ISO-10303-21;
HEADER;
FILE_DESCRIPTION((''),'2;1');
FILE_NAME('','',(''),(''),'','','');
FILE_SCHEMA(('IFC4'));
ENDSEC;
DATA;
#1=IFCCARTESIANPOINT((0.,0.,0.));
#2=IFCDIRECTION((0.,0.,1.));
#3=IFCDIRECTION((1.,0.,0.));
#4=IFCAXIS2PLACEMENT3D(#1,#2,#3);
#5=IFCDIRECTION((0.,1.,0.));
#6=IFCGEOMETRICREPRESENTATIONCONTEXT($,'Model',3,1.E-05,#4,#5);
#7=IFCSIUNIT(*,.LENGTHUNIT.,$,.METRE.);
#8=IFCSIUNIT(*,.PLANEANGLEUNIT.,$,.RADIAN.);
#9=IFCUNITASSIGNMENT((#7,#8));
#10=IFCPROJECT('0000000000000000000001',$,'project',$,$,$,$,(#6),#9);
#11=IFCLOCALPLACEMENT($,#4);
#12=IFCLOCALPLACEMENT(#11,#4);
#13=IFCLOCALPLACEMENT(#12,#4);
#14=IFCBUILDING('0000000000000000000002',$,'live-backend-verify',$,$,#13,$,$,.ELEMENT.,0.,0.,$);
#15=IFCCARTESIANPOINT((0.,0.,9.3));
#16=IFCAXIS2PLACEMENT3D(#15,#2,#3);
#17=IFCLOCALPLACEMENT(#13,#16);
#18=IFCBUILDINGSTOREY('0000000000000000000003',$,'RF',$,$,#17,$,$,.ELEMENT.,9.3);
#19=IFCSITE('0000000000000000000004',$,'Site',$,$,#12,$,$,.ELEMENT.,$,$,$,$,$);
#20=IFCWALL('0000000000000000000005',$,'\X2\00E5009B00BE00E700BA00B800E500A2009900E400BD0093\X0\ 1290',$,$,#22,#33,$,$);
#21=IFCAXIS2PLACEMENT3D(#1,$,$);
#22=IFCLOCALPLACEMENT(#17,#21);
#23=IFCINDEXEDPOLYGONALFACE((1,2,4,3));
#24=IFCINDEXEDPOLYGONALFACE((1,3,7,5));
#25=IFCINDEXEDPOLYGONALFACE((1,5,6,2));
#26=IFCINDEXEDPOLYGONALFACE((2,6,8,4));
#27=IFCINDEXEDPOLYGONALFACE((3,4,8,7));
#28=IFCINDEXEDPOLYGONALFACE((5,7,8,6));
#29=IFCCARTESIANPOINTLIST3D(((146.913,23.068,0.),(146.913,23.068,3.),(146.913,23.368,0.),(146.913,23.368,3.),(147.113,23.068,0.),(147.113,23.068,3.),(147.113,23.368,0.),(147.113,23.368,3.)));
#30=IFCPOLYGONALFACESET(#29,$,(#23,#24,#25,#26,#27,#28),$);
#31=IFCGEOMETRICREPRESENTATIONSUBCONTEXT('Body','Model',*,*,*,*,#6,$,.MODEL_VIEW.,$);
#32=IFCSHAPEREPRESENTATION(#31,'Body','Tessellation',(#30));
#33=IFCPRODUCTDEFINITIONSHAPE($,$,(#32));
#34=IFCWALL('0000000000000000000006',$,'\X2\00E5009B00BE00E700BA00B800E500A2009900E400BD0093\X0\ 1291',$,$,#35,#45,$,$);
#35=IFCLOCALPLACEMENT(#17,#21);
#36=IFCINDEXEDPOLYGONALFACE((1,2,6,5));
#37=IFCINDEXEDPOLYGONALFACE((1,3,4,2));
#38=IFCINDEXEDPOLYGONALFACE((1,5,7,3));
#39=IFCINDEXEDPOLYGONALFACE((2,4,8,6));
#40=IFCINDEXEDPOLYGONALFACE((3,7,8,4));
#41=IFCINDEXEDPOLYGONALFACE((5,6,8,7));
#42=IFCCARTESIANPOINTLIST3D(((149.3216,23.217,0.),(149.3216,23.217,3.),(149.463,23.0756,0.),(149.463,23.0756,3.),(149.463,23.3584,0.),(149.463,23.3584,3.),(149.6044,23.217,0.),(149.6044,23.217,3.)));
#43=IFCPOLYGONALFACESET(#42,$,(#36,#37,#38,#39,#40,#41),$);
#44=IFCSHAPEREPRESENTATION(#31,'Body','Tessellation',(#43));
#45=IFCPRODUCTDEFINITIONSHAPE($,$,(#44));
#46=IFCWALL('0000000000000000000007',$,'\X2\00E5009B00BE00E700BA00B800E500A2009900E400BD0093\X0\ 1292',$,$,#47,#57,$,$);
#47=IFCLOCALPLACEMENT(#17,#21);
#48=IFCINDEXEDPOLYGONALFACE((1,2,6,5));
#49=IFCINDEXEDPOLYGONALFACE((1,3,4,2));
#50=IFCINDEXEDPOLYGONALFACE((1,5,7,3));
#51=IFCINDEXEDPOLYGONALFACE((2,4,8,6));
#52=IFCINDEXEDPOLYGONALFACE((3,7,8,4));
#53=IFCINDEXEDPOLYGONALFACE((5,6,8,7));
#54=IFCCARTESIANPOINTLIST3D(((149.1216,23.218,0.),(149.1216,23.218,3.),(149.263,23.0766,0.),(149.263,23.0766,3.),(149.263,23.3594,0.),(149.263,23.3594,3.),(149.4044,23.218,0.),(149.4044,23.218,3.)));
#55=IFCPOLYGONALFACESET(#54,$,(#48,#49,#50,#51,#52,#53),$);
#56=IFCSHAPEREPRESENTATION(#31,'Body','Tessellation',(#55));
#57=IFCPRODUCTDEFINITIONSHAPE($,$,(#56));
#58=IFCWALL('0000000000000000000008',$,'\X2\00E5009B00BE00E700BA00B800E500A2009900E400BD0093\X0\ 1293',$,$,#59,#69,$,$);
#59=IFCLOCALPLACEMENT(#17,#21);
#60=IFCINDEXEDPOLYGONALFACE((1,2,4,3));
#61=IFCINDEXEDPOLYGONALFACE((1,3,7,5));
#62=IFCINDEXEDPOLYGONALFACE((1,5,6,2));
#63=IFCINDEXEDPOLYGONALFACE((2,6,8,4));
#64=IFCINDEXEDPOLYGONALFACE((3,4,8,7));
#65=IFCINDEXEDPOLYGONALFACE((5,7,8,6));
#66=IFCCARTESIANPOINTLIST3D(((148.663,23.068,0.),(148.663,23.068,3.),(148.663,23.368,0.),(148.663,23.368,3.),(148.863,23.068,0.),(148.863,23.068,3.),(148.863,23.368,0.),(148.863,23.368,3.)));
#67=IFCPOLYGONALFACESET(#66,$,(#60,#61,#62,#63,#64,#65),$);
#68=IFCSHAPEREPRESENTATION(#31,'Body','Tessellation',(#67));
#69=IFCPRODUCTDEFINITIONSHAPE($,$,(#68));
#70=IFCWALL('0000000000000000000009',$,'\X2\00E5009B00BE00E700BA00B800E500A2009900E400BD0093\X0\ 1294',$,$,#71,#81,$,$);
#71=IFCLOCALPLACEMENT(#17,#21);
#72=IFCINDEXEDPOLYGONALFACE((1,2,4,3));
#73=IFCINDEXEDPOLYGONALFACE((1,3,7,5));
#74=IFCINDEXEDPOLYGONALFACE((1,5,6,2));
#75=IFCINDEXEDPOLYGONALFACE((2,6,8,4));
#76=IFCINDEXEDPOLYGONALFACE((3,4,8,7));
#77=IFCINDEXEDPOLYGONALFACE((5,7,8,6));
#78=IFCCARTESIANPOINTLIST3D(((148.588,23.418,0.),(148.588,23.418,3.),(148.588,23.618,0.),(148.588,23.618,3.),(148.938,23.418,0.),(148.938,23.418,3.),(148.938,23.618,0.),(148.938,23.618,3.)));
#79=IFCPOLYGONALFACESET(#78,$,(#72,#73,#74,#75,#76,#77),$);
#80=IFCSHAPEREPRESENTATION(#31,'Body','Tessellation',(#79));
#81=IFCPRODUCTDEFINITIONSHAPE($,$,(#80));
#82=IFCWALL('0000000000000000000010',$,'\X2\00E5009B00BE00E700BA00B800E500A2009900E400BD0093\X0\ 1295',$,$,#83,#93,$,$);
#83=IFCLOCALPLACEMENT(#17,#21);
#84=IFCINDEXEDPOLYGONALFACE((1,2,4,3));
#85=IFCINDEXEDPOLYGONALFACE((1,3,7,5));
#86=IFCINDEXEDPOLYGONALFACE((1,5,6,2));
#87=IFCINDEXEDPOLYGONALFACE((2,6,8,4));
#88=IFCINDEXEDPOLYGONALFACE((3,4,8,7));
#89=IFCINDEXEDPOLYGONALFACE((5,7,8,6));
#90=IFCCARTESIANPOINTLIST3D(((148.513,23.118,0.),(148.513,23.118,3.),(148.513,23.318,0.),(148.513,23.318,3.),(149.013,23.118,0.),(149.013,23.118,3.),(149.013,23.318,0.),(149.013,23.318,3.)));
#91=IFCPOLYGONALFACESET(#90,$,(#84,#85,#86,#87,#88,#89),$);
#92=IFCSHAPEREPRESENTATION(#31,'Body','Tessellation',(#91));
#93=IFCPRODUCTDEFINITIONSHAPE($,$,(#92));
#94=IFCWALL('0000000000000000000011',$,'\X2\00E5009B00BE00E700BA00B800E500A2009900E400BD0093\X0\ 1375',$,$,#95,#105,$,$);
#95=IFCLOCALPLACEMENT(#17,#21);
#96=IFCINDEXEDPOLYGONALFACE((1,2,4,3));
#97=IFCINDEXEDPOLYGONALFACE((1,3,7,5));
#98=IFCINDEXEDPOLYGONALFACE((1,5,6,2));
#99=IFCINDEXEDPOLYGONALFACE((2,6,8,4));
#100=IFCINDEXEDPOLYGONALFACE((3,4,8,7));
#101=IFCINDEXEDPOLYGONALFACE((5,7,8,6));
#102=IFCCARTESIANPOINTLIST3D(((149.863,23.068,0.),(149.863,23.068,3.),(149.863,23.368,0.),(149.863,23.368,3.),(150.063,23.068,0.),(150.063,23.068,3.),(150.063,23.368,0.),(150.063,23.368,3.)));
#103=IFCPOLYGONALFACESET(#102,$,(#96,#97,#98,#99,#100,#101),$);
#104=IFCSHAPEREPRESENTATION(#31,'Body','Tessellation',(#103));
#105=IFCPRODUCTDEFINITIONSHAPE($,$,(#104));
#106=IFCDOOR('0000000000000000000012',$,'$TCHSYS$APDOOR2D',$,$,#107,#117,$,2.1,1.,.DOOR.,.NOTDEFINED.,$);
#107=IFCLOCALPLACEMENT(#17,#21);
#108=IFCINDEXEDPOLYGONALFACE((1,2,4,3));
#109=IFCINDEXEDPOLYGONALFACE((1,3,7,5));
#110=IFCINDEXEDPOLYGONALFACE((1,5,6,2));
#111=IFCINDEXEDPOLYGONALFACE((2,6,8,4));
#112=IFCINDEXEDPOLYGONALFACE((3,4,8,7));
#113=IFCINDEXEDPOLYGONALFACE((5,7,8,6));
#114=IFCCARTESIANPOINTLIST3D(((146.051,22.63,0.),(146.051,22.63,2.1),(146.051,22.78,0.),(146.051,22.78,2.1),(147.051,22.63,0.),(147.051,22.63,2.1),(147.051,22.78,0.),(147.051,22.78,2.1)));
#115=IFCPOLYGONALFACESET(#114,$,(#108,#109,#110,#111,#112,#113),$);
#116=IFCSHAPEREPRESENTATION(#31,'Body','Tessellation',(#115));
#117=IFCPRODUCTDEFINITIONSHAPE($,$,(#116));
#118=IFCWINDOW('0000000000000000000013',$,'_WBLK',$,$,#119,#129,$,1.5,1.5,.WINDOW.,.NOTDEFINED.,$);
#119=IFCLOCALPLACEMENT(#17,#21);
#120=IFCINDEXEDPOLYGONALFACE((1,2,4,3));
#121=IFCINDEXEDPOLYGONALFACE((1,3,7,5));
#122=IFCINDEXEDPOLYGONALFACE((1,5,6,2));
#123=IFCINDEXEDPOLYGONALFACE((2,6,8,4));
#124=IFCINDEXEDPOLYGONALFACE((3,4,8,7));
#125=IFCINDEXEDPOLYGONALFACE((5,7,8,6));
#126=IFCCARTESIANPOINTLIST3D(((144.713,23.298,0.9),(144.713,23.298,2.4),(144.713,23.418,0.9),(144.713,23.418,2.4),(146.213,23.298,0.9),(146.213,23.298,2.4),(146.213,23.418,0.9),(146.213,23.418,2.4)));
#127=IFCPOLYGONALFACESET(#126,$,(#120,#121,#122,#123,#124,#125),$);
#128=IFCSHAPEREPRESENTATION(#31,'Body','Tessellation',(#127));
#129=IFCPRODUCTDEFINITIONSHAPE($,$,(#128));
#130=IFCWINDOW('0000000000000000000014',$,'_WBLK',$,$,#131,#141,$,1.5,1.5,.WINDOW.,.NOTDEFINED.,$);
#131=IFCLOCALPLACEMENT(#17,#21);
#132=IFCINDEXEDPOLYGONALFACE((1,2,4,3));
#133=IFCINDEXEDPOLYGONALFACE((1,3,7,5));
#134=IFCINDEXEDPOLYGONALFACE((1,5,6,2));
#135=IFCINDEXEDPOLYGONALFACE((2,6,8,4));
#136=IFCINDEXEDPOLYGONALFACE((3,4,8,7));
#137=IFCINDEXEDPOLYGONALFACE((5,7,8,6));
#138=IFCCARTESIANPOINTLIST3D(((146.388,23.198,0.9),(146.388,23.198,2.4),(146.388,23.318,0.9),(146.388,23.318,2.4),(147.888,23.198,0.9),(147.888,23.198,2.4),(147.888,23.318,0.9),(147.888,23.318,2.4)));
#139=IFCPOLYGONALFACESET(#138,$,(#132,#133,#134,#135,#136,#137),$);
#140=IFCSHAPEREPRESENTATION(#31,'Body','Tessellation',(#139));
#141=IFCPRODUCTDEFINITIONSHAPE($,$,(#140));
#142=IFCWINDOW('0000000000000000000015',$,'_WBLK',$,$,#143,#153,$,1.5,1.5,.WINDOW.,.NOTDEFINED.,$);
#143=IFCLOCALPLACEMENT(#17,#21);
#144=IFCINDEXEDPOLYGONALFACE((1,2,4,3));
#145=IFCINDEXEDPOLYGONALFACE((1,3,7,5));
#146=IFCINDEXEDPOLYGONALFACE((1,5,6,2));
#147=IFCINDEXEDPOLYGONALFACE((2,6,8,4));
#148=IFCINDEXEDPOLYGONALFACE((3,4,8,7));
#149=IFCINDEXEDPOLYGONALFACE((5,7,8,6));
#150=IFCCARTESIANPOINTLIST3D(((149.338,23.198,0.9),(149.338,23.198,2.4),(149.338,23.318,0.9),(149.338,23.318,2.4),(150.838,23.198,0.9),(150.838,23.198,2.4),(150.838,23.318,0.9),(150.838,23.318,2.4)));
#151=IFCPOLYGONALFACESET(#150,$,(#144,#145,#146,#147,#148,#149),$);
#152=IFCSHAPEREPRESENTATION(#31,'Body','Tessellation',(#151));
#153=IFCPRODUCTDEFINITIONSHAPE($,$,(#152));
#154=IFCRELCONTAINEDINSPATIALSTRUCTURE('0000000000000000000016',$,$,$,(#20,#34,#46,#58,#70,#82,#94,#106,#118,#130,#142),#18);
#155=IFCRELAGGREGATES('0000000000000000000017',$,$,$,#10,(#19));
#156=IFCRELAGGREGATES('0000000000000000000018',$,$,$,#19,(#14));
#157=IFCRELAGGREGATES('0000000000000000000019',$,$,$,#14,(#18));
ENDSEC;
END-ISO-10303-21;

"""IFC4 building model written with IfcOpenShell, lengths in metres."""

from ifc_helpers import new_model, si_unit, direction, frame, frame_2d, origin_with_axes, place, context, subcontext, project, spatial, rectangle, extrude, element, save


model = new_model("IFC4")

# Units and contexts
model_context = context("Model", 3, precision=1e-05, world=origin_with_axes(), true_north=direction((0.0, 1.0, 0.0)))
body_context = subcontext(model_context, "Body", "Model", "MODEL_VIEW")
ifc_project = project(units=[si_unit("LENGTHUNIT", "METRE"), si_unit("PLANEANGLEUNIT", "RADIAN")], contexts=[model_context])

# Site, building, storey
placement = place(None, origin_with_axes())
site_placement = place(placement, origin_with_axes())
site = spatial("IfcSite", under=ifc_project, at=site_placement, Name="Site", CompositionType="ELEMENT")
building_placement = place(site_placement, origin_with_axes())
building = spatial("IfcBuilding", under=site, at=building_placement, Name="live-backend-verify", CompositionType="ELEMENT", ElevationOfRefHeight=0.0, ElevationOfTerrain=0.0)
storey_placement = place(building_placement, frame((0.0, 0.0, 9.3), z_axis=(0.0, 0.0, 1.0), x_axis=(1.0, 0.0, 0.0)))
storey = spatial("IfcBuildingStorey", under=building, at=storey_placement, Name="RF", CompositionType="ELEMENT", Elevation=9.3)

# Walls
wall_1_placement = place(storey_placement, frame((147.013, 23.218, 0.0), z_axis=(0.0, 0.0, 1.0), x_axis=(0.0, 1.0, 0.0)))
element("IfcWall", 1, at=wall_1_placement, inside=storey, Name="å\u009b¾çº¸å¢\u0099ä½\u0093 1290", context=body_context, shape_type="SweptSolid", body=[
    extrude(rectangle(XDim=0.3, YDim=0.2, at=frame_2d((0.0, 0.0), x_axis=(1.0, 0.0, 0.0))), frame((0.0, 0.0, 0.0), z_axis=(0.0, 0.0, 1.0)), (0.0, 0.0, 1.0), 3.0),
])
for number, where, z_axis, x_axis, name in (
    (2, (149.463, 23.217, 0.0), (0.0, 0.0, 1.0), (0.707107, 0.707107, 0.0), "å\u009b¾çº¸å¢\u0099ä½\u0093 1291"),
    (3, (149.263, 23.218, 0.0), (0.0, 0.0, 1.0), (0.707107, -0.707107, 0.0), "å\u009b¾çº¸å¢\u0099ä½\u0093 1292"),
):
    element("IfcWall", number, at=place(storey_placement, frame(where, z_axis=z_axis, x_axis=x_axis)), inside=storey, Name=name, context=body_context, shape_type="SweptSolid", body=[
        extrude(rectangle(XDim=0.2, YDim=0.2, at=frame_2d((0.0, 0.0), x_axis=(1.0, 0.0, 0.0))), frame((0.0, 0.0, 0.0), z_axis=(0.0, 0.0, 1.0)), (0.0, 0.0, 1.0), 3.0),
    ])
wall_2_placement = place(storey_placement, frame((148.763, 23.218, 0.0), z_axis=(0.0, 0.0, 1.0), x_axis=(0.0, 1.0, 0.0)))
element("IfcWall", 4, at=wall_2_placement, inside=storey, Name="å\u009b¾çº¸å¢\u0099ä½\u0093 1293", context=body_context, shape_type="SweptSolid", body=[
    extrude(rectangle(XDim=0.3, YDim=0.2, at=frame_2d((0.0, 0.0), x_axis=(1.0, 0.0, 0.0))), frame((0.0, 0.0, 0.0), z_axis=(0.0, 0.0, 1.0)), (0.0, 0.0, 1.0), 3.0),
])
wall_3_placement = place(storey_placement, frame((148.763, 23.518, 0.0), z_axis=(0.0, 0.0, 1.0), x_axis=(1.0, 0.0, 0.0)))
element("IfcWall", 5, at=wall_3_placement, inside=storey, Name="å\u009b¾çº¸å¢\u0099ä½\u0093 1294", context=body_context, shape_type="SweptSolid", body=[
    extrude(rectangle(XDim=0.35, YDim=0.2, at=frame_2d((0.0, 0.0), x_axis=(1.0, 0.0, 0.0))), frame((0.0, 0.0, 0.0), z_axis=(0.0, 0.0, 1.0)), (0.0, 0.0, 1.0), 3.0),
])
wall_4_placement = place(storey_placement, frame((148.763, 23.218, 0.0), z_axis=(0.0, 0.0, 1.0), x_axis=(1.0, 0.0, 0.0)))
element("IfcWall", 6, at=wall_4_placement, inside=storey, Name="å\u009b¾çº¸å¢\u0099ä½\u0093 1295", context=body_context, shape_type="SweptSolid", body=[
    extrude(rectangle(XDim=0.5, YDim=0.2, at=frame_2d((0.0, 0.0), x_axis=(1.0, 0.0, 0.0))), frame((0.0, 0.0, 0.0), z_axis=(0.0, 0.0, 1.0)), (0.0, 0.0, 1.0), 3.0),
])
wall_5_placement = place(storey_placement, frame((149.963, 23.218, 0.0), z_axis=(0.0, 0.0, 1.0), x_axis=(0.0, 1.0, 0.0)))
element("IfcWall", 7, at=wall_5_placement, inside=storey, Name="å\u009b¾çº¸å¢\u0099ä½\u0093 1375", context=body_context, shape_type="SweptSolid", body=[
    extrude(rectangle(XDim=0.3, YDim=0.2, at=frame_2d((0.0, 0.0), x_axis=(1.0, 0.0, 0.0))), frame((0.0, 0.0, 0.0), z_axis=(0.0, 0.0, 1.0)), (0.0, 0.0, 1.0), 3.0),
])

# Door
door_placement = place(storey_placement, frame((146.551, 22.705, 0.0), z_axis=(0.0, 0.0, 1.0), x_axis=(1.0, 0.0, 0.0)))
element("IfcDoor", 8, at=door_placement, inside=storey, Name="$TCHSYS$APDOOR2D", OperationType="NOTDEFINED", OverallHeight=2.1, OverallWidth=1.0, PredefinedType="DOOR", context=body_context, shape_type="SweptSolid", body=[
    extrude(rectangle(XDim=1.0, YDim=0.15, at=frame_2d((0.0, 0.0), x_axis=(1.0, 0.0, 0.0))), frame((0.0, 0.0, 0.0), z_axis=(0.0, 0.0, 1.0)), (0.0, 0.0, 1.0), 2.1),
])

# Windows
for number, where, z_axis, x_axis, name in (
    (9, (145.463, 23.358, 0.9), (0.0, 0.0, 1.0), (1.0, 0.0, 0.0), "_WBLK"),
    (10, (147.138, 23.258, 0.9), (0.0, 0.0, 1.0), (1.0, 0.0, 0.0), "_WBLK"),
    (11, (150.088, 23.258, 0.9), (0.0, 0.0, 1.0), (1.0, 0.0, 0.0), "_WBLK"),
):
    element("IfcWindow", number, at=place(storey_placement, frame(where, z_axis=z_axis, x_axis=x_axis)), inside=storey, Name=name, OverallHeight=1.5, OverallWidth=1.5, PartitioningType="NOTDEFINED", PredefinedType="WINDOW", context=body_context, shape_type="SweptSolid", body=[
        extrude(rectangle(XDim=1.5, YDim=0.12, at=frame_2d((0.0, 0.0), x_axis=(1.0, 0.0, 0.0))), frame((0.0, 0.0, 0.0), z_axis=(0.0, 0.0, 1.0)), (0.0, 0.0, 1.0), 1.5),
    ])

save(model, "model.ifc")
